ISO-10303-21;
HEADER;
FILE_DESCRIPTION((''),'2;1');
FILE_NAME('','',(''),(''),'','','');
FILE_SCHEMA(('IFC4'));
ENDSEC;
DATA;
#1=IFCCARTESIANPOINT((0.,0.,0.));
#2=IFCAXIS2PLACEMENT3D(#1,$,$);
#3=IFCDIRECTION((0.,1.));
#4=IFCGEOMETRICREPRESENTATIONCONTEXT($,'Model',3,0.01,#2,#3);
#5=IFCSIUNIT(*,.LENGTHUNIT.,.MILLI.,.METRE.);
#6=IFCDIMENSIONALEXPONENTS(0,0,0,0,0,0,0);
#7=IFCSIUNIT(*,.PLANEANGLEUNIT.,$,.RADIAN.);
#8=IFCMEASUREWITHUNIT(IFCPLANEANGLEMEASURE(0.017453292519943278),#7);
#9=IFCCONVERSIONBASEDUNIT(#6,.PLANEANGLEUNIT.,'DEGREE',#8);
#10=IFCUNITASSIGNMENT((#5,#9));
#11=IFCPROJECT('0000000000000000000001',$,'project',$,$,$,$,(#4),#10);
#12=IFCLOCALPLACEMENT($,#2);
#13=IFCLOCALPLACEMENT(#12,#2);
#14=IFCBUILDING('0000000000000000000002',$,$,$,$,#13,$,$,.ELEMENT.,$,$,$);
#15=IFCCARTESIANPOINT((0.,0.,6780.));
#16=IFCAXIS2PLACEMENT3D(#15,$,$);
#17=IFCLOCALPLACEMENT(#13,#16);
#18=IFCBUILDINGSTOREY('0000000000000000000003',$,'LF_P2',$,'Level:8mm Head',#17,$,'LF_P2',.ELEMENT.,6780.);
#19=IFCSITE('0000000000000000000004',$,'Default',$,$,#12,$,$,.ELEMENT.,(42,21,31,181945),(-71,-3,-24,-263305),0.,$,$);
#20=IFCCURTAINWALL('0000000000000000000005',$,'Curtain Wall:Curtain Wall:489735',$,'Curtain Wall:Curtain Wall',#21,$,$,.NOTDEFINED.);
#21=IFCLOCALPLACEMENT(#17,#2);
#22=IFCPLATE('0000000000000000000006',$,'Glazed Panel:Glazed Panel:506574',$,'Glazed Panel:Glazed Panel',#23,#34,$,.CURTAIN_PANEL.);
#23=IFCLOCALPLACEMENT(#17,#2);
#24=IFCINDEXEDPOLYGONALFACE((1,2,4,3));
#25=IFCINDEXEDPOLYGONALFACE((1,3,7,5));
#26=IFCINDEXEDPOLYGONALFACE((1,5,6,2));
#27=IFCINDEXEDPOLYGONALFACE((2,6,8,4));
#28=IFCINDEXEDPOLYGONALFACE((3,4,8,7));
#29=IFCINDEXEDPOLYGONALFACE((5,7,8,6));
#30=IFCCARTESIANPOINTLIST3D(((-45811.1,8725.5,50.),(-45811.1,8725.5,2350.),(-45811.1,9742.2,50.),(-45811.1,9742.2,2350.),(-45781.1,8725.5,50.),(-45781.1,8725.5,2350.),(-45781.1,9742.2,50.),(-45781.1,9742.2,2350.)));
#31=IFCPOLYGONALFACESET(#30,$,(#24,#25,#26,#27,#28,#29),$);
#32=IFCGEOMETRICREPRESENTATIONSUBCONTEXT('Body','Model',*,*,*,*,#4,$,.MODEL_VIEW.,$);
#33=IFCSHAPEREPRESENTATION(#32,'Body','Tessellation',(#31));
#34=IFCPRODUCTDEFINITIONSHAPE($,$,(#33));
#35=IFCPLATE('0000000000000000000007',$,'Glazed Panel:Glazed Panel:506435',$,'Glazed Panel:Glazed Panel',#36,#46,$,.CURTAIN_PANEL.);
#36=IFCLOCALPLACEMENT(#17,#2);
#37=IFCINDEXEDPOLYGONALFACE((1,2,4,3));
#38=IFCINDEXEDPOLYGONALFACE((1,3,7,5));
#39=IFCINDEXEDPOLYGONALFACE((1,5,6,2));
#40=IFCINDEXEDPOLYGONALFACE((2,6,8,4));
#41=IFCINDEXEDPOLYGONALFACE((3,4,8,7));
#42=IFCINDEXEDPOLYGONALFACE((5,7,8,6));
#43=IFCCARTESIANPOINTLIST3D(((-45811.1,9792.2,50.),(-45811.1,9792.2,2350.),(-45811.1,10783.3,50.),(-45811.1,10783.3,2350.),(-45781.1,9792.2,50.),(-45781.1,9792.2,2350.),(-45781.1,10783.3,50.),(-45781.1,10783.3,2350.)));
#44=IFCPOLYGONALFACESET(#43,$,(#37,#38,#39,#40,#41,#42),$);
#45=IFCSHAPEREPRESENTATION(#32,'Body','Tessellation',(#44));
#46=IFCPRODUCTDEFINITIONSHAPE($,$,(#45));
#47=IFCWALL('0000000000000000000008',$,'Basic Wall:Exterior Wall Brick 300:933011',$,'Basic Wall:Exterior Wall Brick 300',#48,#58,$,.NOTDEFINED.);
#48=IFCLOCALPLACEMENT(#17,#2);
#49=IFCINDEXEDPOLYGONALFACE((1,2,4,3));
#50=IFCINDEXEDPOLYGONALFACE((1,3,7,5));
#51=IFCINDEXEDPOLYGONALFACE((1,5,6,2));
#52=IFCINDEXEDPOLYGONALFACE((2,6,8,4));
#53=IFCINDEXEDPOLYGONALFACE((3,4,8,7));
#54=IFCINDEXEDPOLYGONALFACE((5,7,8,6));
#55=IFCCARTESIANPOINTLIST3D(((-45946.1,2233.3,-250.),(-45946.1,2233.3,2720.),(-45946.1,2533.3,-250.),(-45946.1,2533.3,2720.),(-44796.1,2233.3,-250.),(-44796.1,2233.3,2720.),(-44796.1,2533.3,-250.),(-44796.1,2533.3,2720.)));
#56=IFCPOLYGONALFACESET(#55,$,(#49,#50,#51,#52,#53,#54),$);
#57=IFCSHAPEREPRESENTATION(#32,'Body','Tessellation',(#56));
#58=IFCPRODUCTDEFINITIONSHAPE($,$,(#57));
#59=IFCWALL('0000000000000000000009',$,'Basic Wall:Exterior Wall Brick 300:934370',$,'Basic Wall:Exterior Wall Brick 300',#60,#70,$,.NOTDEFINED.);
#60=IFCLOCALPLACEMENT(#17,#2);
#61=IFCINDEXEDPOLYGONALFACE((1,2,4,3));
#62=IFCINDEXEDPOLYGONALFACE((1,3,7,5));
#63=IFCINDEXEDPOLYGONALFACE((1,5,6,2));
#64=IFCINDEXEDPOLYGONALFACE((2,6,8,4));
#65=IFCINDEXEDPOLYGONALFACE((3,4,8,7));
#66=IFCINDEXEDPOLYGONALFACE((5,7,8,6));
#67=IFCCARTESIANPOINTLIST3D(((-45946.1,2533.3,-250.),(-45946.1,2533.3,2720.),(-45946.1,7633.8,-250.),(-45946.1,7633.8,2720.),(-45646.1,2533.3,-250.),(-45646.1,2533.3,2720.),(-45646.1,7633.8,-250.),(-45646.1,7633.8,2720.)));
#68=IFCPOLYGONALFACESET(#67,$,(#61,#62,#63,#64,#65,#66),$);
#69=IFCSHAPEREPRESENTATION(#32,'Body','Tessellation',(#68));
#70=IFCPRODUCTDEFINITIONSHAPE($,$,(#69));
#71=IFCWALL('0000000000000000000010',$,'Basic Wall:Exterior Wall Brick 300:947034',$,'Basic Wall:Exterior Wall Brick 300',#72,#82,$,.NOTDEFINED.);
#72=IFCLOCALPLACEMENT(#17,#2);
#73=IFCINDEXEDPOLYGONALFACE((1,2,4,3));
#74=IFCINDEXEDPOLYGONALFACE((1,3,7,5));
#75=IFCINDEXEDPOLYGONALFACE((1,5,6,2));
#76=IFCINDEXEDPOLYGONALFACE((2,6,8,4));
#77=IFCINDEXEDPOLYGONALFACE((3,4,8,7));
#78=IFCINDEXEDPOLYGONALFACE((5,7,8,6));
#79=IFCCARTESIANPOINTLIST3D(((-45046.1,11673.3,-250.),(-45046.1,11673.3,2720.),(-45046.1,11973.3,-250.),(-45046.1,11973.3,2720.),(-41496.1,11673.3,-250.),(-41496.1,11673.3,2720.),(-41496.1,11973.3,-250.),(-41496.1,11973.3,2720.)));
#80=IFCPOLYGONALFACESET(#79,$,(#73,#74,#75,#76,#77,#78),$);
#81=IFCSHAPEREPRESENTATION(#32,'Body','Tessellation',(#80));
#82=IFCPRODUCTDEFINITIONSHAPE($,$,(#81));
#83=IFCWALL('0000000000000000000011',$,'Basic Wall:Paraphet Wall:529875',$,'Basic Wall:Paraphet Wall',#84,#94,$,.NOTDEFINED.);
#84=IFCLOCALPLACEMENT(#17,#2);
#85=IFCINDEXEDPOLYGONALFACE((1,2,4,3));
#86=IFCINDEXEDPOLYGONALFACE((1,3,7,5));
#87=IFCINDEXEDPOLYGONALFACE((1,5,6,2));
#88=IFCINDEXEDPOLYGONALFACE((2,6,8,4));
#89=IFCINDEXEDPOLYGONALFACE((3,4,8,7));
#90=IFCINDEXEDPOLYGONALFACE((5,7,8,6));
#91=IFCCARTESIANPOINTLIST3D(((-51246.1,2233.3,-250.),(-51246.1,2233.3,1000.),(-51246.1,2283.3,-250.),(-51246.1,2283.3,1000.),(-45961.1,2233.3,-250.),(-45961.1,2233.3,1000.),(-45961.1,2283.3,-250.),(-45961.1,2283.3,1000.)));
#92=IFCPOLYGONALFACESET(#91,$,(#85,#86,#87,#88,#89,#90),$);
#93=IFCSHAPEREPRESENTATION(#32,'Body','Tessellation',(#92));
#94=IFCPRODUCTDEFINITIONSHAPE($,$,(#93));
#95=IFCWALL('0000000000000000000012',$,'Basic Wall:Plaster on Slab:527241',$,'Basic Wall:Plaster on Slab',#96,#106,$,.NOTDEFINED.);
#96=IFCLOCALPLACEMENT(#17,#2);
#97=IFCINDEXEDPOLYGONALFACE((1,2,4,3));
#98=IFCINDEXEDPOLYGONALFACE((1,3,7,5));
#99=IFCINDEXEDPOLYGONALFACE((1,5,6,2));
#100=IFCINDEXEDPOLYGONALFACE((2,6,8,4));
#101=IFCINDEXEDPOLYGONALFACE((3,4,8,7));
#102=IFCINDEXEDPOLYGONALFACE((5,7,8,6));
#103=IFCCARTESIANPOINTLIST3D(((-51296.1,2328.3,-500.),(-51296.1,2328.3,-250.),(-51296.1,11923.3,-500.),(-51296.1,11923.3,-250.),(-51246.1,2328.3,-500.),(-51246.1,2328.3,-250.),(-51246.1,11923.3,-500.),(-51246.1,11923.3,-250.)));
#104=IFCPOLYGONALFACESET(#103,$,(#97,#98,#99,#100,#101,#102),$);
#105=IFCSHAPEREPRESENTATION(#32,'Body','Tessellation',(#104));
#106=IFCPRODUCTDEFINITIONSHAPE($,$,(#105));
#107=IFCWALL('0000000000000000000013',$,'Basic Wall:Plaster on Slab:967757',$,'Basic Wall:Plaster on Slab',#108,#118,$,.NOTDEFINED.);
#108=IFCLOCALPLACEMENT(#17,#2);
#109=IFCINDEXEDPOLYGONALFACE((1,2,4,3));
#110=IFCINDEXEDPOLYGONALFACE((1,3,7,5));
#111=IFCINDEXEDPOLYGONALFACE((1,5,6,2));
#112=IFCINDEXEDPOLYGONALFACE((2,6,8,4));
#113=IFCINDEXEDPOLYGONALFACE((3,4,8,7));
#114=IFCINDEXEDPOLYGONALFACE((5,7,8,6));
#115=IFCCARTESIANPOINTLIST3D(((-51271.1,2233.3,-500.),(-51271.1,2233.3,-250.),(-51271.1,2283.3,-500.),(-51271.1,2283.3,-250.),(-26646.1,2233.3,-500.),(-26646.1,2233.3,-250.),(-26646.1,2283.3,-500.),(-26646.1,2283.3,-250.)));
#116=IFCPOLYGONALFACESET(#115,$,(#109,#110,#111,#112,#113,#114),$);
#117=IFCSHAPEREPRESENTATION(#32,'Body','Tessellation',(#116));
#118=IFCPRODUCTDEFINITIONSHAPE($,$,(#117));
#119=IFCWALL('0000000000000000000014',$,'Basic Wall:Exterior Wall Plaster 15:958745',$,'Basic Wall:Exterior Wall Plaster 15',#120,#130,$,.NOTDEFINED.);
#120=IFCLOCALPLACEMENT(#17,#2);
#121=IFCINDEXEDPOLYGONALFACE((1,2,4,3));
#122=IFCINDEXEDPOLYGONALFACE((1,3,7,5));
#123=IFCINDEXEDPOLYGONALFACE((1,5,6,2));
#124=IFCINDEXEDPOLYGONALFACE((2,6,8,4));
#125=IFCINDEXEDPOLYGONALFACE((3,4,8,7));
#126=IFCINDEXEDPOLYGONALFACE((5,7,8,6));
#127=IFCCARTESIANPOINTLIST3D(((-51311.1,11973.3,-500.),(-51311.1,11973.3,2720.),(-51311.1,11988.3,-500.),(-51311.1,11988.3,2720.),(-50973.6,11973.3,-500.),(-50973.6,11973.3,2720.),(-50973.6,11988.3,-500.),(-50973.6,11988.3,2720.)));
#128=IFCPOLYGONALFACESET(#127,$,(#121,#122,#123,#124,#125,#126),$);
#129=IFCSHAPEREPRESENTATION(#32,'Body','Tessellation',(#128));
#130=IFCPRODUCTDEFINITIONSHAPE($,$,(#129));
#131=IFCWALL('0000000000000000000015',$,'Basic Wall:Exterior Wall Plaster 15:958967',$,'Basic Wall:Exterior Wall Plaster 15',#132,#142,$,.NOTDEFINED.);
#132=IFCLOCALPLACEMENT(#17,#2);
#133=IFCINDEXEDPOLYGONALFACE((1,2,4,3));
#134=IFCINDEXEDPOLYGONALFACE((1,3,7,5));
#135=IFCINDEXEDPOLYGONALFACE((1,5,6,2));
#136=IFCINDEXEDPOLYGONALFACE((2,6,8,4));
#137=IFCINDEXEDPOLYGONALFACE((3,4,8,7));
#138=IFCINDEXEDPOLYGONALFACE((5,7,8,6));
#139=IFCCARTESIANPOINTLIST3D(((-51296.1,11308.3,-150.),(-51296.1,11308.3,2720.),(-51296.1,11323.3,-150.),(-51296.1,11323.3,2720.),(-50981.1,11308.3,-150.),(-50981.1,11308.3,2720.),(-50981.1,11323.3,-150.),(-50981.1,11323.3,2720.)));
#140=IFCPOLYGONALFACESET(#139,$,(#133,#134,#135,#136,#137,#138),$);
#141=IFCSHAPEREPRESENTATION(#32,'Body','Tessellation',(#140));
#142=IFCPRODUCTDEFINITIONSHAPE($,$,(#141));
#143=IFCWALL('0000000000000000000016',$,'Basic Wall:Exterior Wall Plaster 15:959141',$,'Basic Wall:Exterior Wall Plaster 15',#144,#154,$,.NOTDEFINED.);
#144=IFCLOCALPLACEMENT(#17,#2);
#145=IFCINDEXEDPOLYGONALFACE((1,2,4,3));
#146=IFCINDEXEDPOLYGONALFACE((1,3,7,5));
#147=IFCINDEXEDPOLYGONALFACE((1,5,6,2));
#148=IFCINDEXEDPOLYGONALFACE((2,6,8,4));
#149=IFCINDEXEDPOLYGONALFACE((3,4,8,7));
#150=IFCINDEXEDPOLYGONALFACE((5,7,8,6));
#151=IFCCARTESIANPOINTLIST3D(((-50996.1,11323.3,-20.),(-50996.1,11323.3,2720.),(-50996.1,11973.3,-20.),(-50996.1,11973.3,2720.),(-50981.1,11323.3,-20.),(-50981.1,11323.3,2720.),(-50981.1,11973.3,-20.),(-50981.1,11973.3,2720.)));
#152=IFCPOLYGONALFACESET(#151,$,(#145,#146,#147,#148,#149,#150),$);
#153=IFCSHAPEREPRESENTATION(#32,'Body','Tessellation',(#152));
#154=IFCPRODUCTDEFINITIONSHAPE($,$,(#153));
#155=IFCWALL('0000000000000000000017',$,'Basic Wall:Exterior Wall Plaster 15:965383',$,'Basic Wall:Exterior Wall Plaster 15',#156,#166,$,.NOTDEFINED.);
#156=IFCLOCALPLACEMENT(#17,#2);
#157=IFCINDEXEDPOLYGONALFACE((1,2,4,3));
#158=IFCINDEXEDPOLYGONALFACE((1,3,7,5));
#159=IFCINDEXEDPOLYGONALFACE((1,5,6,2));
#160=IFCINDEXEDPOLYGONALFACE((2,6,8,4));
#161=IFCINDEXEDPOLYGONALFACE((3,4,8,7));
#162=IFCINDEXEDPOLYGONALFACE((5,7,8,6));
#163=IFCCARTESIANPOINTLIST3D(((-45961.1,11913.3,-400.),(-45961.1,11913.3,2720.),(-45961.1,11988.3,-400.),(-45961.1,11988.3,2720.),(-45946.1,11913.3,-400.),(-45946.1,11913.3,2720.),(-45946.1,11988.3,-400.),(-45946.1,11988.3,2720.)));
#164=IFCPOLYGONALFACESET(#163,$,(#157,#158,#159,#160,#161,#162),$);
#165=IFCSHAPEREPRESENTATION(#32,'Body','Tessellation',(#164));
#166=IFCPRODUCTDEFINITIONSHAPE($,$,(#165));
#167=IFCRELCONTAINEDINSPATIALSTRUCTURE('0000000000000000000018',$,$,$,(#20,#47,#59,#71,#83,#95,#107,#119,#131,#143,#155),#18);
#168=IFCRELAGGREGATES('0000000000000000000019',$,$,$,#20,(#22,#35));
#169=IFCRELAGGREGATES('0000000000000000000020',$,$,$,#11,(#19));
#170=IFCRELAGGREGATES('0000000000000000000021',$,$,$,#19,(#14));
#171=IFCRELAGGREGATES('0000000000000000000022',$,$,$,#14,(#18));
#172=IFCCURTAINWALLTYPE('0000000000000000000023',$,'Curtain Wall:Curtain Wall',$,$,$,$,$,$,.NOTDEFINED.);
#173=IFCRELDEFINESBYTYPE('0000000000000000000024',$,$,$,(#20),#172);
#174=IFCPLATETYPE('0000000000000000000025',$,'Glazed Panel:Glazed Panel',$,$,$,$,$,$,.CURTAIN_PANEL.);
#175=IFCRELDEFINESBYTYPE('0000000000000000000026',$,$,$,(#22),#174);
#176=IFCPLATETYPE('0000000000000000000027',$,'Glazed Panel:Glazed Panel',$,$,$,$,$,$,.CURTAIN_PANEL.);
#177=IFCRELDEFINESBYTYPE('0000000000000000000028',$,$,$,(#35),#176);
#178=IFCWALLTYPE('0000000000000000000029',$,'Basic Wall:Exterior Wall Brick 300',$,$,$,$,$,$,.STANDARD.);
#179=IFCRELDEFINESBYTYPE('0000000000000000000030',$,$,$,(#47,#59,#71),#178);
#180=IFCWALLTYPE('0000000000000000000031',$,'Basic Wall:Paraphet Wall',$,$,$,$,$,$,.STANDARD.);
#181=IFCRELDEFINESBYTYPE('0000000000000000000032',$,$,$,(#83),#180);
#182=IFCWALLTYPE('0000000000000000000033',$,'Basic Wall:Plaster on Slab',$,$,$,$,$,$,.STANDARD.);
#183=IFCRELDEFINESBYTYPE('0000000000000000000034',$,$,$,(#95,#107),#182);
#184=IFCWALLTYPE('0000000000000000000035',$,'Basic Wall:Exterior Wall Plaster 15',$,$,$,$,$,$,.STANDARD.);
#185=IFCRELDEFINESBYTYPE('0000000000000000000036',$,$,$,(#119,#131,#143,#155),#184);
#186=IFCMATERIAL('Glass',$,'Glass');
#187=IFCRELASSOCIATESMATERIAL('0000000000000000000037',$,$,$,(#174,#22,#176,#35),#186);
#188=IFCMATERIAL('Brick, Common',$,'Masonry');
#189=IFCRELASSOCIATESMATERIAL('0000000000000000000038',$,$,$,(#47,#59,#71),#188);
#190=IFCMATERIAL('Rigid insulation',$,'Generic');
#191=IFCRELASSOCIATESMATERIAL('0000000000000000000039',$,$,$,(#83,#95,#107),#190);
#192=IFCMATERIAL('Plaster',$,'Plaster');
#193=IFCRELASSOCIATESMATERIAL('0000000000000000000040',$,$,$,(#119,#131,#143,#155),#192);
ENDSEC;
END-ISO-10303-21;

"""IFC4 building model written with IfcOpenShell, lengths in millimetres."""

from ifc_helpers import new_model, entity, si_unit, converted_unit, direction, frame, origin, place, context, subcontext, project, spatial, indexed_curve, outline, extrude, source, transform, mapped, material, type_object, type_shapes, element, aggregate, save


model = new_model("IFC4")

# Units and contexts
model_context = context("Model", 3, precision=0.01, world=origin(), true_north=direction((0.0, 1.0)))
body_context = subcontext(model_context, "Body", "Model", "MODEL_VIEW")
ifc_project = project(units=[si_unit("LENGTHUNIT", "METRE", prefix="MILLI"), converted_unit("PLANEANGLEUNIT", "DEGREE", entity("IfcPlaneAngleMeasure", 0.017453292519943278), si_unit("PLANEANGLEUNIT", "RADIAN"), dimensions=[0, 0, 0, 0, 0, 0, 0])], contexts=[model_context])

# Site, building, storey
site_placement = place(None, origin())
site = spatial("IfcSite", under=ifc_project, at=site_placement, Name="Default", CompositionType="ELEMENT", RefLatitude=(42, 21, 31, 181945), RefLongitude=(-71, -3, -24, -263305), RefElevation=0.0)
building_placement = place(site_placement, origin())
building = spatial("IfcBuilding", under=site, at=building_placement, CompositionType="ELEMENT")
storey_placement = place(building_placement, frame((0.0, 0.0, 6780.0)))
storey = spatial("IfcBuildingStorey", under=building, at=storey_placement, Name="LF_P2", ObjectType="Level:8mm Head", LongName="LF_P2", CompositionType="ELEMENT", Elevation=6780.0)

# Curtain wall, plates
curtain_wall_type = type_object("IfcCurtainWallType", Name="Curtain Wall:Curtain Wall", PredefinedType="NOTDEFINED")
curtain_wall_placement = place(storey_placement, frame((0.0, 0.0, -6780.0)))
curtain_wall = element("IfcCurtainWall", 1, at=curtain_wall_placement, inside=storey, type_object=curtain_wall_type, Name="Curtain Wall:Curtain Wall:489735", ObjectType="Curtain Wall:Curtain Wall", PredefinedType="NOTDEFINED")
ifc_material_1 = material(Name="Glass", Category="Glass")
plate_type_1 = type_object("IfcPlateType", Name="Glazed Panel:Glazed Panel", PredefinedType="CURTAIN_PANEL", material=ifc_material_1)
shared_shape_1 = source(origin(), body_context, "Body", "SweptSolid", [
    extrude(outline(indexed_curve([(-15.0, -508.3), (15.0, -508.3), (15.0, 508.3), (-15.0, 508.3), (-15.0, -508.3)], self_intersect=False)), frame((0.0, 0.0, 0.0), z_axis=(0.0, 0.0, 1.0), x_axis=(0.0, 1.0, 0.0)), (0.0, 0.0, 1.0), 2300.0),
])
type_shapes(plate_type_1, [shared_shape_1])
plate_1_placement = place(curtain_wall_placement, frame((-45796.1, 9233.8, 6830.0), z_axis=(0.0, 0.0, 1.0), x_axis=(0.0, 1.0, 0.0)))
plate_1 = element("IfcPlate", 2, at=plate_1_placement, type_object=plate_type_1, material=ifc_material_1, Name="Glazed Panel:Glazed Panel:506574", ObjectType="Glazed Panel:Glazed Panel", PredefinedType="CURTAIN_PANEL", context=body_context, shape_type="MappedRepresentation", body=[
    mapped(shared_shape_1, transform((0.0, 0.0, 0.0), scale=1.0)),
])
plate_type_2 = type_object("IfcPlateType", Name="Glazed Panel:Glazed Panel", PredefinedType="CURTAIN_PANEL", material=ifc_material_1)
shared_shape_2 = source(origin(), body_context, "Body", "SweptSolid", [
    extrude(outline(indexed_curve([(-15.0, -495.6), (15.0, -495.6), (15.0, 495.6), (-15.0, 495.6), (-15.0, -495.6)], self_intersect=False)), frame((0.0, 0.0, 0.0), z_axis=(0.0, 0.0, 1.0), x_axis=(0.0, 1.0, 0.0)), (0.0, 0.0, 1.0), 2300.0),
])
type_shapes(plate_type_2, [shared_shape_2])
plate_2_placement = place(curtain_wall_placement, frame((-45796.1, 10287.7, 6830.0), z_axis=(0.0, 0.0, 1.0), x_axis=(0.0, 1.0, 0.0)))
plate_2 = element("IfcPlate", 3, at=plate_2_placement, type_object=plate_type_2, material=ifc_material_1, Name="Glazed Panel:Glazed Panel:506435", ObjectType="Glazed Panel:Glazed Panel", PredefinedType="CURTAIN_PANEL", context=body_context, shape_type="MappedRepresentation", body=[
    mapped(shared_shape_2, transform((0.0, 0.0, 0.0), scale=1.0)),
])
aggregate(curtain_wall, [plate_1, plate_2])

# Walls
ifc_material_2 = material(Name="Brick, Common", Category="Masonry")
wall_type_1 = type_object("IfcWallType", Name="Basic Wall:Exterior Wall Brick 300", PredefinedType="STANDARD")
wall_1_placement = place(storey_placement, frame((-44796.1, 2383.3, -250.0), z_axis=(0.0, 0.0, 1.0), x_axis=(-1.0, 0.0, 0.0)))
element("IfcWall", 4, at=wall_1_placement, inside=storey, type_object=wall_type_1, material=ifc_material_2, Name="Basic Wall:Exterior Wall Brick 300:933011", ObjectType="Basic Wall:Exterior Wall Brick 300", PredefinedType="NOTDEFINED", context=body_context, shape_type="SweptSolid", body=[
    extrude(outline(indexed_curve([(1150.0, 150.0), (0.0, 150.0), (0.0, -150.0), (1150.0, -150.0), (1150.0, 150.0)], self_intersect=False)), origin(), (0.0, 0.0, 1.0), 2970.0),
])
wall_2_placement = place(storey_placement, frame((-45796.1, 2533.3, -250.0), z_axis=(0.0, 0.0, 1.0), x_axis=(0.0, 1.0, 0.0)))
element("IfcWall", 5, at=wall_2_placement, inside=storey, type_object=wall_type_1, material=ifc_material_2, Name="Basic Wall:Exterior Wall Brick 300:934370", ObjectType="Basic Wall:Exterior Wall Brick 300", PredefinedType="NOTDEFINED", context=body_context, shape_type="SweptSolid", body=[
    extrude(outline(indexed_curve([(5100.5, 150.0), (0.0, 150.0), (0.0, -150.0), (5100.5, -150.0), (5100.5, 150.0)], self_intersect=False)), origin(), (0.0, 0.0, 1.0), 2970.0),
])
wall_3_placement = place(storey_placement, frame((-45046.1, 11823.3, -250.0)))
element("IfcWall", 6, at=wall_3_placement, inside=storey, type_object=wall_type_1, material=ifc_material_2, Name="Basic Wall:Exterior Wall Brick 300:947034", ObjectType="Basic Wall:Exterior Wall Brick 300", PredefinedType="NOTDEFINED", context=body_context, shape_type="SweptSolid", body=[
    extrude(outline(indexed_curve([(3550.0, 150.0), (0.0, 150.0), (0.0, -150.0), (3550.0, -150.0), (3550.0, 150.0)], self_intersect=False)), origin(), (0.0, 0.0, 1.0), 2970.0),
])
ifc_material_3 = material(Name="Rigid insulation", Category="Generic")
wall_type_2 = type_object("IfcWallType", Name="Basic Wall:Paraphet Wall", PredefinedType="STANDARD")
wall_4_placement = place(storey_placement, frame((-51246.1, 2258.3, -250.0)))
element("IfcWall", 7, at=wall_4_placement, inside=storey, type_object=wall_type_2, material=ifc_material_3, Name="Basic Wall:Paraphet Wall:529875", ObjectType="Basic Wall:Paraphet Wall", PredefinedType="NOTDEFINED", context=body_context, shape_type="SweptSolid", body=[
    extrude(outline(indexed_curve([(5285.0, 25.0), (0.0, 25.0), (0.0, -25.0), (5285.0, -25.0), (5285.0, 25.0)], self_intersect=False)), origin(), (0.0, 0.0, 1.0), 1250.0),
])
wall_type_3 = type_object("IfcWallType", Name="Basic Wall:Plaster on Slab", PredefinedType="STANDARD")
wall_5_placement = place(storey_placement, frame((-51271.1, 11923.3, -500.0), z_axis=(0.0, 0.0, 1.0), x_axis=(0.0, -1.0, 0.0)))
element("IfcWall", 8, at=wall_5_placement, inside=storey, type_object=wall_type_3, material=ifc_material_3, Name="Basic Wall:Plaster on Slab:527241", ObjectType="Basic Wall:Plaster on Slab", PredefinedType="NOTDEFINED", context=body_context, shape_type="SweptSolid", body=[
    extrude(outline(indexed_curve([(9595.0, 25.0), (0.0, 25.0), (0.0, -25.0), (9595.0, -25.0), (9595.0, 25.0)], self_intersect=False)), origin(), (0.0, 0.0, 1.0), 250.0),
])
wall_6_placement = place(storey_placement, frame((-51271.1, 2258.3, -500.0)))
element("IfcWall", 9, at=wall_6_placement, inside=storey, type_object=wall_type_3, material=ifc_material_3, Name="Basic Wall:Plaster on Slab:967757", ObjectType="Basic Wall:Plaster on Slab", PredefinedType="NOTDEFINED", context=body_context, shape_type="SweptSolid", body=[
    extrude(outline(indexed_curve([(24625.0, 25.0), (0.0, 25.0), (0.0, -25.0), (24625.0, -25.0), (24625.0, 25.0)], self_intersect=False)), origin(), (0.0, 0.0, 1.0), 250.0),
])
ifc_material_4 = material(Name="Plaster", Category="Plaster")
wall_type_4 = type_object("IfcWallType", Name="Basic Wall:Exterior Wall Plaster 15", PredefinedType="STANDARD")
wall_7_placement = place(storey_placement, frame((-50973.6, 11980.8, -500.0), z_axis=(0.0, 0.0, 1.0), x_axis=(-1.0, 0.0, 0.0)))
element("IfcWall", 10, at=wall_7_placement, inside=storey, type_object=wall_type_4, material=ifc_material_4, Name="Basic Wall:Exterior Wall Plaster 15:958745", ObjectType="Basic Wall:Exterior Wall Plaster 15", PredefinedType="NOTDEFINED", context=body_context, shape_type="SweptSolid", body=[
    extrude(outline(indexed_curve([(337.5, 7.5), (0.0, 7.5), (0.0, -7.5), (337.5, -7.5), (337.5, 7.5)], self_intersect=False)), origin(), (0.0, 0.0, 1.0), 3220.0),
])
wall_8_placement = place(storey_placement, frame((-51296.1, 11315.8, -150.0)))
element("IfcWall", 11, at=wall_8_placement, inside=storey, type_object=wall_type_4, material=ifc_material_4, Name="Basic Wall:Exterior Wall Plaster 15:958967", ObjectType="Basic Wall:Exterior Wall Plaster 15", PredefinedType="NOTDEFINED", context=body_context, shape_type="SweptSolid", body=[
    extrude(outline(indexed_curve([(315.0, 7.5), (0.0, 7.5), (0.0, -7.5), (315.0, -7.5), (315.0, 7.5)], self_intersect=False)), origin(), (0.0, 0.0, 1.0), 2870.0),
])
wall_9_placement = place(storey_placement, frame((-50988.6, 11323.3, -20.0), z_axis=(0.0, 0.0, 1.0), x_axis=(0.0, 1.0, 0.0)))
element("IfcWall", 12, at=wall_9_placement, inside=storey, type_object=wall_type_4, material=ifc_material_4, Name="Basic Wall:Exterior Wall Plaster 15:959141", ObjectType="Basic Wall:Exterior Wall Plaster 15", PredefinedType="NOTDEFINED", context=body_context, shape_type="SweptSolid", body=[
    extrude(outline(indexed_curve([(650.0, 7.5), (0.0, 7.5), (0.0, -7.5), (650.0, -7.5), (650.0, 7.5)], self_intersect=False)), origin(), (0.0, 0.0, 1.0), 2740.0),
])
wall_10_placement = place(storey_placement, frame((-45953.6, 11913.3, -400.0), z_axis=(0.0, 0.0, 1.0), x_axis=(0.0, 1.0, 0.0)))
element("IfcWall", 13, at=wall_10_placement, inside=storey, type_object=wall_type_4, material=ifc_material_4, Name="Basic Wall:Exterior Wall Plaster 15:965383", ObjectType="Basic Wall:Exterior Wall Plaster 15", PredefinedType="NOTDEFINED", context=body_context, shape_type="SweptSolid", body=[
    extrude(outline(indexed_curve([(75.0, 7.5), (0.0, 7.5), (0.0, -7.5), (75.0, -7.5), (75.0, 7.5)], self_intersect=False)), origin(), (0.0, 0.0, 1.0), 3120.0),
])

save(model, "model.ifc")
